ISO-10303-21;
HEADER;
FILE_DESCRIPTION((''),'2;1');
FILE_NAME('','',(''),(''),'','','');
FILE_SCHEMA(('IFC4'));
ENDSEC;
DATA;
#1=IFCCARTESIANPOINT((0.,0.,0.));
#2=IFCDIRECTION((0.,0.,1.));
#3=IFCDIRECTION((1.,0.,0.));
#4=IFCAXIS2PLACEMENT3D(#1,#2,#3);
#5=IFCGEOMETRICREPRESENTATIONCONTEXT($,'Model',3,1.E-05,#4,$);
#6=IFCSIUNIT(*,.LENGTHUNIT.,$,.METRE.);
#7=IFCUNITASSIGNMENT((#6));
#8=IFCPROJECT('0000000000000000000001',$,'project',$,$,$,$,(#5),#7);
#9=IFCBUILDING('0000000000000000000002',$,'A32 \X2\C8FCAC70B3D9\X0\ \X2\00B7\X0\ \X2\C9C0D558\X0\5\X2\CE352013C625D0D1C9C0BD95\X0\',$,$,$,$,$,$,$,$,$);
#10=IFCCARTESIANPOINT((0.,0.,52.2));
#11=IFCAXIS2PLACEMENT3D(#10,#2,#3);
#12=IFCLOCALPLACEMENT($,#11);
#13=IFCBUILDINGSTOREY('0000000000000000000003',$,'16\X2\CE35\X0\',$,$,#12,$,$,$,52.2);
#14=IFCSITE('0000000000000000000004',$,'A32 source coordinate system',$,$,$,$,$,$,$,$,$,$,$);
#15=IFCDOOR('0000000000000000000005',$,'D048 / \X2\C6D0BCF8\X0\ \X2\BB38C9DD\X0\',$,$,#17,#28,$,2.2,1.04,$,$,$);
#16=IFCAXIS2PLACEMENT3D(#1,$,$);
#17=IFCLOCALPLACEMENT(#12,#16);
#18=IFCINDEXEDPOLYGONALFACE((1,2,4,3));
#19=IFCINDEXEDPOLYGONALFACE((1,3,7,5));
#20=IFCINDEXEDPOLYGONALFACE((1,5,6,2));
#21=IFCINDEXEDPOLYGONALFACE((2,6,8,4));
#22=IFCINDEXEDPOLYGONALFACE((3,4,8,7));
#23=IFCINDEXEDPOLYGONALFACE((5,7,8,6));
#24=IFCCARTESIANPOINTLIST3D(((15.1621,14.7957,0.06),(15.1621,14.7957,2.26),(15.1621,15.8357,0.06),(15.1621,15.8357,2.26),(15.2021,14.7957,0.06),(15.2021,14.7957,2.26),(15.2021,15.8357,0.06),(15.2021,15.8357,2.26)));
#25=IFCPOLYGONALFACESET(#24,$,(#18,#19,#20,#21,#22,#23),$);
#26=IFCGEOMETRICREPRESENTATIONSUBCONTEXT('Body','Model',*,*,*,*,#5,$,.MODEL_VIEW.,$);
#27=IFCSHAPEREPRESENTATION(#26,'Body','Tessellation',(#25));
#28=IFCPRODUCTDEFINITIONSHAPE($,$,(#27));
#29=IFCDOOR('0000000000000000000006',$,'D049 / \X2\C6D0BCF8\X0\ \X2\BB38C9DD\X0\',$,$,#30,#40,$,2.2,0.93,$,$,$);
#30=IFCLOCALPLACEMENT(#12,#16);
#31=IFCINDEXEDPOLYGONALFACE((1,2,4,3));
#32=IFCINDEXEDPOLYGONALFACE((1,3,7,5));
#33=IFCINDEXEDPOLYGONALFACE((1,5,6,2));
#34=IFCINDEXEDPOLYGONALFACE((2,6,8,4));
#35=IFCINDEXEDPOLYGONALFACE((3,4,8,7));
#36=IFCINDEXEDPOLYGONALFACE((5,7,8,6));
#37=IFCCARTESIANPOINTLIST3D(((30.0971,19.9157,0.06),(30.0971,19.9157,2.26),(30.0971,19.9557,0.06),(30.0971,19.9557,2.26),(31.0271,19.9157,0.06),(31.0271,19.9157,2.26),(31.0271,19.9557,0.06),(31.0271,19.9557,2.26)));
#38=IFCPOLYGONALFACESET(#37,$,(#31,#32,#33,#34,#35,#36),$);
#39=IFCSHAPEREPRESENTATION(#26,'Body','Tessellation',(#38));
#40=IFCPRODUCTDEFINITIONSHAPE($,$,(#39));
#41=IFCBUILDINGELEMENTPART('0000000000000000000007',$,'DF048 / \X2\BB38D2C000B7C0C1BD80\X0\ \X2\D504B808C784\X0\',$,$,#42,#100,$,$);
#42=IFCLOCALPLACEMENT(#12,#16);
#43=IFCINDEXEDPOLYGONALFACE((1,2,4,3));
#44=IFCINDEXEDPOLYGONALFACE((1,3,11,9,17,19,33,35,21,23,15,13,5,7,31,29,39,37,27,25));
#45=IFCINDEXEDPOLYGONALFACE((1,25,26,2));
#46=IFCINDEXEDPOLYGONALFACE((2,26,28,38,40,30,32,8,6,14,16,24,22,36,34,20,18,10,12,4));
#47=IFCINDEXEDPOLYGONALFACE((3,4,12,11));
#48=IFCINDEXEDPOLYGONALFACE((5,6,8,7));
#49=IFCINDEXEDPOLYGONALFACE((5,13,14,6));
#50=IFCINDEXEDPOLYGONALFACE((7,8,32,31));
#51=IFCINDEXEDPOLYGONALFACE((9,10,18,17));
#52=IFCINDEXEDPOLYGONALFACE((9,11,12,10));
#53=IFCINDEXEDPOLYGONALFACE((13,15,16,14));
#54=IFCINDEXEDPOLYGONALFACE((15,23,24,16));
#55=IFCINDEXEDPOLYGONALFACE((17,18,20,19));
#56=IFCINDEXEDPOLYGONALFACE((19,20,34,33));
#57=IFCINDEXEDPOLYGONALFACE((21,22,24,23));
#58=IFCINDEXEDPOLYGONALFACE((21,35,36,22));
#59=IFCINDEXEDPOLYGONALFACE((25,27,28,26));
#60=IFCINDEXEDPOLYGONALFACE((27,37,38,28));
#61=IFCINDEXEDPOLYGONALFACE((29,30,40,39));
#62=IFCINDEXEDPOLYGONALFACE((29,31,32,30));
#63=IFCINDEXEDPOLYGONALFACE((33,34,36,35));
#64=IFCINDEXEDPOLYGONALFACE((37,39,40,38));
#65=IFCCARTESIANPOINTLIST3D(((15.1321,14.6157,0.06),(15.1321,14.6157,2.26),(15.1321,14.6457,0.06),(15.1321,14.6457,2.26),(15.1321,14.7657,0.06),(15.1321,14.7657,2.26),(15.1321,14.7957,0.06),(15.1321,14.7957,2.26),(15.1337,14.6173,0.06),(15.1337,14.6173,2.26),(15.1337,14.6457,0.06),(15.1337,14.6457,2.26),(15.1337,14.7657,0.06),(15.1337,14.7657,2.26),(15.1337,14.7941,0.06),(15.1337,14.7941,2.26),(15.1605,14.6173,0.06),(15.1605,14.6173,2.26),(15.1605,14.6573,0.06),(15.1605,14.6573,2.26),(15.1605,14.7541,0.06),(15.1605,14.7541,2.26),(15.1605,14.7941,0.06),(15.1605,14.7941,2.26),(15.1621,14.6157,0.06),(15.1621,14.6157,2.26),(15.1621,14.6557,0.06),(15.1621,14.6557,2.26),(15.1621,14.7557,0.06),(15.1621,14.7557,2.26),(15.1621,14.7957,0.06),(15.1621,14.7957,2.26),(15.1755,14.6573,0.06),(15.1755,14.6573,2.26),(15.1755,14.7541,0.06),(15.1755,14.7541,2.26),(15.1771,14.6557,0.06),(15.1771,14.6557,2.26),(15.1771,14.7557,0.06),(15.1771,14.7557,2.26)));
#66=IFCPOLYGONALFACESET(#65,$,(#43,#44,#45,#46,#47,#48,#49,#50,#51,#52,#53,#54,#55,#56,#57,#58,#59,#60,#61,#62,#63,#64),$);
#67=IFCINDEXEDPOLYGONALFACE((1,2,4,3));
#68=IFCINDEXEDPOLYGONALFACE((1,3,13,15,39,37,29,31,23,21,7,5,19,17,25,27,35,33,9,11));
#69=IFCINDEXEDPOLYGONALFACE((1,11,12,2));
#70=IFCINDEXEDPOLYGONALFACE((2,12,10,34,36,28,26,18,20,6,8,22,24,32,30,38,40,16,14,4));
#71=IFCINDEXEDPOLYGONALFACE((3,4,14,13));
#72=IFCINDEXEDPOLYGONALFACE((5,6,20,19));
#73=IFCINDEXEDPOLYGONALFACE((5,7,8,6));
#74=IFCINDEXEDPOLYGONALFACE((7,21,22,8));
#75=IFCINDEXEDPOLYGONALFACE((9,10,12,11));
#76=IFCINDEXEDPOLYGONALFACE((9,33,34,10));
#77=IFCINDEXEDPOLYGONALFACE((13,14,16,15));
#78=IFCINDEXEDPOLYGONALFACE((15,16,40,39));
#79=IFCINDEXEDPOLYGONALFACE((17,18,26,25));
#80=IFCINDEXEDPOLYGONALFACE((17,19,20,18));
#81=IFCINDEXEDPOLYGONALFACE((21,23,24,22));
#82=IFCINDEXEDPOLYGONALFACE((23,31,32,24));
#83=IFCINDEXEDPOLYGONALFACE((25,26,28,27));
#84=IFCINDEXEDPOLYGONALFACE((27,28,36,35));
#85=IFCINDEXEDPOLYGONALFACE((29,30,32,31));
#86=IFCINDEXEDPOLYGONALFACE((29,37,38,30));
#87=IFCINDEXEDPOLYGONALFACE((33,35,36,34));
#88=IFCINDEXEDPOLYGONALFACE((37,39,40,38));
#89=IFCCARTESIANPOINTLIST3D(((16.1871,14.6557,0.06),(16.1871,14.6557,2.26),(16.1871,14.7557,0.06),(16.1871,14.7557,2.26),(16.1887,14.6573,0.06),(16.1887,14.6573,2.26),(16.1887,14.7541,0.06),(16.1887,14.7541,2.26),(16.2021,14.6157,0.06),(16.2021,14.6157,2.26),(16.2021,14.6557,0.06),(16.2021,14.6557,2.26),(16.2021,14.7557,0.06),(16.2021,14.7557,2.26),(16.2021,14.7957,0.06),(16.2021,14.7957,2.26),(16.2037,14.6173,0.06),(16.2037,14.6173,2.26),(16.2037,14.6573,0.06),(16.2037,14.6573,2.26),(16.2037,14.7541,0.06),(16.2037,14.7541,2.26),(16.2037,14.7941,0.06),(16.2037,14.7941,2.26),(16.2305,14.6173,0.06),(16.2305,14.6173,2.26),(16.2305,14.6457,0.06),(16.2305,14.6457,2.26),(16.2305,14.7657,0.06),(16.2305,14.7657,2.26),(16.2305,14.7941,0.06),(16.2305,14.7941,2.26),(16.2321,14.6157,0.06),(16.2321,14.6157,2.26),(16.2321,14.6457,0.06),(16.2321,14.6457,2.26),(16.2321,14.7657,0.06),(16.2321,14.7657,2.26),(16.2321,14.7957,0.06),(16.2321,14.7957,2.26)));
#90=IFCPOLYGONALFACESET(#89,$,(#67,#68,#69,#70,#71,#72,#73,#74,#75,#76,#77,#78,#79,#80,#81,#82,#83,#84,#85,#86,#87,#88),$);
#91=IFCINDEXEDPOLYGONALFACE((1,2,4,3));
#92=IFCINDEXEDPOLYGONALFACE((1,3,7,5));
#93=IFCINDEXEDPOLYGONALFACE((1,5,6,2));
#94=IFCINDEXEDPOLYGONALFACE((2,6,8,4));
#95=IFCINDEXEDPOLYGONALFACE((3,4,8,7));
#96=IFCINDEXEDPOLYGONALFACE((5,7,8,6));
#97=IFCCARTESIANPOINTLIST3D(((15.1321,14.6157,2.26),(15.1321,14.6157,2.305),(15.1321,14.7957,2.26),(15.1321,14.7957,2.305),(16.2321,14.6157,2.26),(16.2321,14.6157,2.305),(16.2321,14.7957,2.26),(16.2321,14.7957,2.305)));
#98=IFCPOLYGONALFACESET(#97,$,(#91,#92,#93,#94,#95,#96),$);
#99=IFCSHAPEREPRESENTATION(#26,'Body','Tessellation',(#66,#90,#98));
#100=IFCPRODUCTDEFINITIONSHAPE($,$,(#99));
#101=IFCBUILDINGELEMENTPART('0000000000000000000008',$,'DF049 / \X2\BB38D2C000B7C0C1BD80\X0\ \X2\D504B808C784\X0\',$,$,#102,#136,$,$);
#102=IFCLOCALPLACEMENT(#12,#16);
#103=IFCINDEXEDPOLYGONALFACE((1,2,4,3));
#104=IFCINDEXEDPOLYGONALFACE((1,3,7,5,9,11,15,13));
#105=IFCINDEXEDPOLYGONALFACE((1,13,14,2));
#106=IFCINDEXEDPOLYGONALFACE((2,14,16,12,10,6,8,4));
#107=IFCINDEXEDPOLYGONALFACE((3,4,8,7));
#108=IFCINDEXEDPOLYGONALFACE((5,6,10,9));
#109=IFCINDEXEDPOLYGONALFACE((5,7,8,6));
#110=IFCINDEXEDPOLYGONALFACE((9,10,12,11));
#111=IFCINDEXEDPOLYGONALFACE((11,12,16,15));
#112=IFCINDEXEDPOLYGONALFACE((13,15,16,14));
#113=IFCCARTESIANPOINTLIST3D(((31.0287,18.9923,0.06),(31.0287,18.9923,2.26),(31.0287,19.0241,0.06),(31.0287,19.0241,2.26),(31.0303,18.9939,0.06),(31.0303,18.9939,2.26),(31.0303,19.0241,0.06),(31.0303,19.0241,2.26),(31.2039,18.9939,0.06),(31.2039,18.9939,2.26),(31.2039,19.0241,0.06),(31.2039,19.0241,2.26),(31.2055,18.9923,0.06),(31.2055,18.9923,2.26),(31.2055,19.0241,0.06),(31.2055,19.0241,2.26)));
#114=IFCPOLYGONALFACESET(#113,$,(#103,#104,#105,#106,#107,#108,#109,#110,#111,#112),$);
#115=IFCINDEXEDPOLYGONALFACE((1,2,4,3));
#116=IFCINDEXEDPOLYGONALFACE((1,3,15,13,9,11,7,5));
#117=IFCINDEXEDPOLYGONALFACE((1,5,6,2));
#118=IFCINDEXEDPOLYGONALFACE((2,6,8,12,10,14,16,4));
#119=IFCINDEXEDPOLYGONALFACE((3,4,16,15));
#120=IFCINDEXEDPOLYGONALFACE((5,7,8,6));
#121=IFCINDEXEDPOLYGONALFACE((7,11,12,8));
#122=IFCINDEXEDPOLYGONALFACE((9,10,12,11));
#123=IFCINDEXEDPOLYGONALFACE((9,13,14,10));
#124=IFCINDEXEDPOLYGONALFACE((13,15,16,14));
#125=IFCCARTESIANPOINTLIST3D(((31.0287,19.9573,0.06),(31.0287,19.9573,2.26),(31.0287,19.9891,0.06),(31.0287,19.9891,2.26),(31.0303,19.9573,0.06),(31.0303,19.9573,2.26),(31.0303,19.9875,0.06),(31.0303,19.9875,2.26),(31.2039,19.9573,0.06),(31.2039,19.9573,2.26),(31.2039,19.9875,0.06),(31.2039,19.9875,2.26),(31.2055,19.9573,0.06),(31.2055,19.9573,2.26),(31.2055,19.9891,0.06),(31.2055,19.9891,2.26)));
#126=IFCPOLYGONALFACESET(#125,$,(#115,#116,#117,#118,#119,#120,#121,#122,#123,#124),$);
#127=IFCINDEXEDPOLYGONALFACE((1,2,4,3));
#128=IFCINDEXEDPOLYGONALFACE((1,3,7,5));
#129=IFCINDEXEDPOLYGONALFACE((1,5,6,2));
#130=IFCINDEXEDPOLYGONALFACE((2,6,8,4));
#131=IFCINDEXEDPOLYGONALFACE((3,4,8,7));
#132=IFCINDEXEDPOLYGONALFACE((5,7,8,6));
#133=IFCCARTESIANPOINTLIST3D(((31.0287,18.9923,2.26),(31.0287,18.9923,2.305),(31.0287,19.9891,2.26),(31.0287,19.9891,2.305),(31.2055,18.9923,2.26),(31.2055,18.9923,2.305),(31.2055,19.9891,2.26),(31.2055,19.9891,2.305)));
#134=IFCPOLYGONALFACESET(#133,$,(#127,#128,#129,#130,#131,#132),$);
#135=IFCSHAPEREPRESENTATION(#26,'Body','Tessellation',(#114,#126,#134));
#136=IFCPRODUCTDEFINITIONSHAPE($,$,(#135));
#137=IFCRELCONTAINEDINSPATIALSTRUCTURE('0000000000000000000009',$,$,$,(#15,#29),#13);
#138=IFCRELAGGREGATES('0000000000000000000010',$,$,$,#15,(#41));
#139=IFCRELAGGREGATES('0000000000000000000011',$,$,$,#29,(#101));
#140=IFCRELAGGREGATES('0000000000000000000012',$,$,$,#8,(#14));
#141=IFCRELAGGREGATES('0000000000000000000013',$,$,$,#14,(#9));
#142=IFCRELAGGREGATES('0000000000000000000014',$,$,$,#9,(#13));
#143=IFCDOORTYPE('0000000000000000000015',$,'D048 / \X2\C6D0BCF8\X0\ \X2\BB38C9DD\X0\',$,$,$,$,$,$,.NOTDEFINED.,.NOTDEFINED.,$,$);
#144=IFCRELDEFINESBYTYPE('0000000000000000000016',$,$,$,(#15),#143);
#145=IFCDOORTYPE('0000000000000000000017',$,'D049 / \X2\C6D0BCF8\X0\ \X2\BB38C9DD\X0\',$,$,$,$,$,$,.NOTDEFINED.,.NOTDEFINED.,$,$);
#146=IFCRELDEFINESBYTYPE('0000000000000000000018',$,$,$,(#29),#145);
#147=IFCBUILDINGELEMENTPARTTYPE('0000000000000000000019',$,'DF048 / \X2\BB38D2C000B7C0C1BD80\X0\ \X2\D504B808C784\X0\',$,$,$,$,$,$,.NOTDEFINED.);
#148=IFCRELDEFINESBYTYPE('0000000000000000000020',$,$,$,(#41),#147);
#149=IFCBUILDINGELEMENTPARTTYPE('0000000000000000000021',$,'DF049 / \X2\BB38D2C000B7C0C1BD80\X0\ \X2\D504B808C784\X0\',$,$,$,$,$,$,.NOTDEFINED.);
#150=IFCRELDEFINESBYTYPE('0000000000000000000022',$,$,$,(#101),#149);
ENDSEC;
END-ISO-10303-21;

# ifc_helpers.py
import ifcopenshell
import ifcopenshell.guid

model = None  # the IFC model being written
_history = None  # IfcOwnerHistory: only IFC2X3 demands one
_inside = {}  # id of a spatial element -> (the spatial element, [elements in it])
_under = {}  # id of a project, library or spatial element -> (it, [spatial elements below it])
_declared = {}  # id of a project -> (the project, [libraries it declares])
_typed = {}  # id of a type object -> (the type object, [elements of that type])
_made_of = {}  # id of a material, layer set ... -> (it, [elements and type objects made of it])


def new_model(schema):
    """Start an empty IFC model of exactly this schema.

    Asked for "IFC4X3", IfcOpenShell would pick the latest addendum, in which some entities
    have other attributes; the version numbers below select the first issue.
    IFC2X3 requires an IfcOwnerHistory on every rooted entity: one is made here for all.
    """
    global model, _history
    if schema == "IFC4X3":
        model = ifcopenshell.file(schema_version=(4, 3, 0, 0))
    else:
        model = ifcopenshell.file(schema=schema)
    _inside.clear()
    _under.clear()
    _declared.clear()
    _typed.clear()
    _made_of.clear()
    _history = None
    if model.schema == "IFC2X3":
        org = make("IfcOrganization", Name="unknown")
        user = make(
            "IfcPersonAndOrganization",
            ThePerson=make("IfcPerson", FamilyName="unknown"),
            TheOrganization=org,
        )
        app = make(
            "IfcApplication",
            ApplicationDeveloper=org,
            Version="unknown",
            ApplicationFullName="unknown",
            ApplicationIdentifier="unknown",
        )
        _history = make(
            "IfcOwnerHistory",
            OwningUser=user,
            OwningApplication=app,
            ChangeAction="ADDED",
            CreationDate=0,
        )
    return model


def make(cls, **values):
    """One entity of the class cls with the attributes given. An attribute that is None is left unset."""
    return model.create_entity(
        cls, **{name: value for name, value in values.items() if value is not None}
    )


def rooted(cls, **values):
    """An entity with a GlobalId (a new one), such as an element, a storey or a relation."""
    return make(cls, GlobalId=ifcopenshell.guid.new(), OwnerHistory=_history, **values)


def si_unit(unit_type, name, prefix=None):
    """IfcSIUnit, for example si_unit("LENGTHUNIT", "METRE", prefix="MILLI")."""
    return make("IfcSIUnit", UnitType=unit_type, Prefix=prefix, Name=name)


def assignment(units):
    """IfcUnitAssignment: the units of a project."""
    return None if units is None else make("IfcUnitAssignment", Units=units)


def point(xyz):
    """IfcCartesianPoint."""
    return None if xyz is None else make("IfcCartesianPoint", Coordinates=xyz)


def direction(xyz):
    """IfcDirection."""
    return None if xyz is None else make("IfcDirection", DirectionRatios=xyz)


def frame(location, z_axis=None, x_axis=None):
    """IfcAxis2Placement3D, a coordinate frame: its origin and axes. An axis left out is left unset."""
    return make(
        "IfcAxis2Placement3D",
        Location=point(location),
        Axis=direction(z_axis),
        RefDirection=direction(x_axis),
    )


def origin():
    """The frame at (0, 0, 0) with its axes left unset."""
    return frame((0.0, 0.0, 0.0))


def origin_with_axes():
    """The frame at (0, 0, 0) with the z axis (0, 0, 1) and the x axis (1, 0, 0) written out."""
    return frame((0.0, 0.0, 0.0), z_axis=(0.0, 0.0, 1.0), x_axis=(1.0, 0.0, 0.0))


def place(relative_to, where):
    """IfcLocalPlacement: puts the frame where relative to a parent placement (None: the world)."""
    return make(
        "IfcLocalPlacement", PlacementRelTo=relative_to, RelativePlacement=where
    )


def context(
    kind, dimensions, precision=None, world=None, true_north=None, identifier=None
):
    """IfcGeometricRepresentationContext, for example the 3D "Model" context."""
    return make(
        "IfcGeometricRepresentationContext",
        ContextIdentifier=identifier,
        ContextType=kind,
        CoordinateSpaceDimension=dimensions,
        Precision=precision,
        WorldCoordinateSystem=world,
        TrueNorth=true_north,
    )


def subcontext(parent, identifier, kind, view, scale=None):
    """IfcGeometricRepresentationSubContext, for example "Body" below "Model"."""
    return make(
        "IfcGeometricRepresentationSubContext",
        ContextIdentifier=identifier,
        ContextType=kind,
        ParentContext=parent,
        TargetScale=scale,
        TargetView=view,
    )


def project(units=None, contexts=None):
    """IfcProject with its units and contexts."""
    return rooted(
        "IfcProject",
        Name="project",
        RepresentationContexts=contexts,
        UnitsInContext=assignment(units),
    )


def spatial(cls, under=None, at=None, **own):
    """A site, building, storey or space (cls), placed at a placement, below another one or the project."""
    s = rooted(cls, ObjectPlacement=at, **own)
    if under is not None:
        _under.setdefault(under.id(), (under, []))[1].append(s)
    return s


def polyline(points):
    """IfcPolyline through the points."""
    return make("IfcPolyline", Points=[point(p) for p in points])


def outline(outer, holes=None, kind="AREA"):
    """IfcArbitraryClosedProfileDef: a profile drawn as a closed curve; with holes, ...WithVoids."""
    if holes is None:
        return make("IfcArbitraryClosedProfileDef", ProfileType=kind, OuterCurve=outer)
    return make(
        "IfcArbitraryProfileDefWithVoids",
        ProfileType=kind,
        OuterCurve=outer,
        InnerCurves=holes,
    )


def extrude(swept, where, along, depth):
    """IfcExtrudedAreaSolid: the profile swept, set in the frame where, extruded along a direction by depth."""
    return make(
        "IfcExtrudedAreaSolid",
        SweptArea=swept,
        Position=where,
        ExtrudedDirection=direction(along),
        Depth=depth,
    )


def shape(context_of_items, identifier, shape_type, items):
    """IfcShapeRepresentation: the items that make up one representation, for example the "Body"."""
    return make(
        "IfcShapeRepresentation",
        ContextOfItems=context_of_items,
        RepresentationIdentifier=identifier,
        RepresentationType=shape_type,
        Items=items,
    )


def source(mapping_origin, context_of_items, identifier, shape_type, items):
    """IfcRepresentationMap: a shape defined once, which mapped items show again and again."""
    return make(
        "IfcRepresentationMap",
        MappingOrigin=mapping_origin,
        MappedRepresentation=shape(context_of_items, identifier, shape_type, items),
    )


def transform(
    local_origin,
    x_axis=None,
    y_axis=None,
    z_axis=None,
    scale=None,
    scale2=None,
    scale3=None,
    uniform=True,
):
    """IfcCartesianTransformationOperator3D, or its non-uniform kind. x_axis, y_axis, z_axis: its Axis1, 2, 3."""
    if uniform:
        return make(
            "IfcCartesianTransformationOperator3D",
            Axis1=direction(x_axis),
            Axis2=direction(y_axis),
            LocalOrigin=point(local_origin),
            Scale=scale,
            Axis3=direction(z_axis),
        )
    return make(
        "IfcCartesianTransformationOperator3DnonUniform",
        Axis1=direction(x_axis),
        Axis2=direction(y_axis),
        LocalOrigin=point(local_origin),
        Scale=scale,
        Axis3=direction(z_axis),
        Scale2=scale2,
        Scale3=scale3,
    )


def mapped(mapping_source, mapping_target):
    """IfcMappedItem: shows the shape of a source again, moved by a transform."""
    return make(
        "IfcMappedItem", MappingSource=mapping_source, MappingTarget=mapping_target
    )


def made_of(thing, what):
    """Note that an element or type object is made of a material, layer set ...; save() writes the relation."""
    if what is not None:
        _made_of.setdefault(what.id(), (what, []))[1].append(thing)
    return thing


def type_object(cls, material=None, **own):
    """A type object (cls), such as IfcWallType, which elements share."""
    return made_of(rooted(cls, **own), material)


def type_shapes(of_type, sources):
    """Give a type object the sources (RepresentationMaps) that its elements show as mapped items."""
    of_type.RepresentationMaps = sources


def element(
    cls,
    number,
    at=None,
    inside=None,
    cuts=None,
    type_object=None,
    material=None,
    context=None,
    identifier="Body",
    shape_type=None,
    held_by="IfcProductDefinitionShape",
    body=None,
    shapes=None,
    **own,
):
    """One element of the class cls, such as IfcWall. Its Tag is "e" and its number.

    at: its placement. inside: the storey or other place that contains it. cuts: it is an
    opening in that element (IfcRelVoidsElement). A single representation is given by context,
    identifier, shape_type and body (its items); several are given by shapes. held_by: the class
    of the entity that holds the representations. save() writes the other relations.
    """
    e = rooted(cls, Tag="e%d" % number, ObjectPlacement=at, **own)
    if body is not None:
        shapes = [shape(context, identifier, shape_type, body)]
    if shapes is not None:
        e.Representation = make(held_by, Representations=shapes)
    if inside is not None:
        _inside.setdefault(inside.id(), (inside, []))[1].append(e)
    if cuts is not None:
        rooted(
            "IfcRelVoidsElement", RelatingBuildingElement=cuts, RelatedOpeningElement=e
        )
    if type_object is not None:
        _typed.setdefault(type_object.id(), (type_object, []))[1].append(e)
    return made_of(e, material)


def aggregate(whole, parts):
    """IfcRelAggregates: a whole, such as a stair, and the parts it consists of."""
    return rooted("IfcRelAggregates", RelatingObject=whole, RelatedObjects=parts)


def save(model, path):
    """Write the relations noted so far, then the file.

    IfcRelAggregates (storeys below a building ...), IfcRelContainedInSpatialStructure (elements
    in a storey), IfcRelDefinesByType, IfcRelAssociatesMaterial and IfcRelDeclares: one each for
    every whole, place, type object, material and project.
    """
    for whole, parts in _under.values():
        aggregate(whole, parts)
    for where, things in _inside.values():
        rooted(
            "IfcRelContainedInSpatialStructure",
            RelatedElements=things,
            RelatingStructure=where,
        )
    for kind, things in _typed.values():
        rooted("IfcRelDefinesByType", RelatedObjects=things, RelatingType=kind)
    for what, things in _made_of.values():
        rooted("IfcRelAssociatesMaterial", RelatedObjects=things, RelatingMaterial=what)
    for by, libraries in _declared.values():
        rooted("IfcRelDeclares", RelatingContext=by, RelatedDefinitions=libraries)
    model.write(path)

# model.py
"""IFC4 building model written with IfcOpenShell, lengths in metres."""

from ifc_helpers import new_model, si_unit, frame, origin, origin_with_axes, place, context, subcontext, project, spatial, polyline, outline, extrude, source, transform, mapped, type_object, type_shapes, element, aggregate, save


model = new_model("IFC4")

# Units and contexts
model_context = context("Model", 3, precision=1e-05, world=origin_with_axes())
body_context = subcontext(model_context, "Body", "Model", "MODEL_VIEW")
ifc_project = project(units=[si_unit("LENGTHUNIT", "METRE")], contexts=[model_context])

# Site, building, storey
storey_placement = place(None, frame((0.0, 0.0, 52.2), z_axis=(0.0, 0.0, 1.0), x_axis=(1.0, 0.0, 0.0)))
site = spatial("IfcSite", under=ifc_project, Name="A32 source coordinate system")
building = spatial("IfcBuilding", under=site, Name="A32 주거동 · 지하5층–옥탑지붕")
storey = spatial("IfcBuildingStorey", under=building, at=storey_placement, Name="16층", Elevation=52.2)

# Doors
door_type_1 = type_object("IfcDoorType", Name="D048 / 원본 문짝", OperationType="NOTDEFINED", PredefinedType="NOTDEFINED")
shared_shape_1 = source(origin(), body_context, "Body", "SweptSolid", [
    extrude(outline(polyline([(15.2021, 15.8357), (15.2021, 14.7957), (15.1621, 14.7957), (15.1621, 15.8357), (15.2021, 15.8357)])), frame((0.0, 0.0, 0.06)), (0.0, 0.0, 1.0), 2.2),
])
type_shapes(door_type_1, [shared_shape_1])
door_1_placement = place(storey_placement, origin_with_axes())
door_1 = element("IfcDoor", 1, at=door_1_placement, inside=storey, type_object=door_type_1, Name="D048 / 원본 문짝", OverallHeight=2.2, OverallWidth=1.04, context=body_context, shape_type="MappedRepresentation", body=[
    mapped(shared_shape_1, transform((0.0, 0.0, 0.0), scale=1.0)),
])
door_type_2 = type_object("IfcDoorType", Name="D049 / 원본 문짝", OperationType="NOTDEFINED", PredefinedType="NOTDEFINED")
shared_shape_2 = source(origin(), body_context, "Body", "SweptSolid", [
    extrude(outline(polyline([(31.0271, 19.9557), (31.0271, 19.9157), (30.0971, 19.9157), (30.0971, 19.9557), (31.0271, 19.9557)])), frame((0.0, 0.0, 0.06)), (0.0, 0.0, 1.0), 2.2),
])
type_shapes(door_type_2, [shared_shape_2])
door_2_placement = place(storey_placement, origin_with_axes())
door_2 = element("IfcDoor", 2, at=door_2_placement, inside=storey, type_object=door_type_2, Name="D049 / 원본 문짝", OverallHeight=2.2, OverallWidth=0.93, context=body_context, shape_type="MappedRepresentation", body=[
    mapped(shared_shape_2, transform((0.0, 0.0, 0.0), scale=1.0)),
])

# Building element parts
building_element_part_type_1 = type_object("IfcBuildingElementPartType", Name="DF048 / 문틀·상부 프레임", PredefinedType="NOTDEFINED")
shared_shape_3 = source(origin(), body_context, "Body", "SweptSolid", [
    extrude(outline(polyline([(15.1321, 14.7657), (15.1321, 14.7957), (15.1621, 14.7957), (15.1621, 14.7557), (15.1771, 14.7557), (15.1771, 14.6557), (15.1621, 14.6557), (15.1621, 14.6157), (15.1321, 14.6157), (15.1321, 14.6457), (15.1337, 14.6457), (15.1337, 14.6173), (15.1605, 14.6173), (15.1605, 14.6573), (15.1755, 14.6573), (15.1755, 14.7541), (15.1605, 14.7541), (15.1605, 14.7941), (15.1337, 14.7941), (15.1337, 14.7657), (15.1321, 14.7657)])), frame((0.0, 0.0, 0.06)), (0.0, 0.0, 1.0), 2.2),
    extrude(outline(polyline([(16.2305, 14.7941), (16.2037, 14.7941), (16.2037, 14.7541), (16.1887, 14.7541), (16.1887, 14.6573), (16.2037, 14.6573), (16.2037, 14.6173), (16.2305, 14.6173), (16.2305, 14.6457), (16.2321, 14.6457), (16.2321, 14.6157), (16.2021, 14.6157), (16.2021, 14.6557), (16.1871, 14.6557), (16.1871, 14.7557), (16.2021, 14.7557), (16.2021, 14.7957), (16.2321, 14.7957), (16.2321, 14.7657), (16.2305, 14.7657), (16.2305, 14.7941)])), frame((0.0, 0.0, 0.06)), (0.0, 0.0, 1.0), 2.2),
    extrude(outline(polyline([(15.1321, 14.6157), (15.1321, 14.7957), (16.2321, 14.7957), (16.2321, 14.6157), (15.1321, 14.6157)])), frame((0.0, 0.0, 2.26)), (0.0, 0.0, 1.0), 0.045),
])
type_shapes(building_element_part_type_1, [shared_shape_3])
building_element_part_1_placement = place(door_1_placement, origin_with_axes())
building_element_part_1 = element("IfcBuildingElementPart", 3, at=building_element_part_1_placement, type_object=building_element_part_type_1, Name="DF048 / 문틀·상부 프레임", context=body_context, shape_type="MappedRepresentation", body=[
    mapped(shared_shape_3, transform((0.0, 0.0, 0.0), scale=1.0)),
])
aggregate(door_1, [building_element_part_1])
building_element_part_type_2 = type_object("IfcBuildingElementPartType", Name="DF049 / 문틀·상부 프레임", PredefinedType="NOTDEFINED")
shared_shape_4 = source(origin(), body_context, "Body", "SweptSolid", [
    extrude(outline(polyline([(31.0303, 19.0241), (31.0303, 18.9939), (31.2039, 18.9939), (31.2039, 19.0241), (31.2055, 19.0241), (31.2055, 18.9923), (31.0287, 18.9923), (31.0287, 19.0241), (31.0303, 19.0241)])), frame((0.0, 0.0, 0.06)), (0.0, 0.0, 1.0), 2.2),
    extrude(outline(polyline([(31.0287, 19.9891), (31.2055, 19.9891), (31.2055, 19.9573), (31.2039, 19.9573), (31.2039, 19.9875), (31.0303, 19.9875), (31.0303, 19.9573), (31.0287, 19.9573), (31.0287, 19.9891)])), frame((0.0, 0.0, 0.06)), (0.0, 0.0, 1.0), 2.2),
    extrude(outline(polyline([(31.0287, 18.9923), (31.0287, 19.9891), (31.2055, 19.9891), (31.2055, 18.9923), (31.0287, 18.9923)])), frame((0.0, 0.0, 2.26)), (0.0, 0.0, 1.0), 0.045),
])
type_shapes(building_element_part_type_2, [shared_shape_4])
building_element_part_2_placement = place(door_2_placement, origin_with_axes())
building_element_part_2 = element("IfcBuildingElementPart", 4, at=building_element_part_2_placement, type_object=building_element_part_type_2, Name="DF049 / 문틀·상부 프레임", context=body_context, shape_type="MappedRepresentation", body=[
    mapped(shared_shape_4, transform((0.0, 0.0, 0.0), scale=1.0)),
])
aggregate(door_2, [building_element_part_2])

save(model, "model.ifc")
